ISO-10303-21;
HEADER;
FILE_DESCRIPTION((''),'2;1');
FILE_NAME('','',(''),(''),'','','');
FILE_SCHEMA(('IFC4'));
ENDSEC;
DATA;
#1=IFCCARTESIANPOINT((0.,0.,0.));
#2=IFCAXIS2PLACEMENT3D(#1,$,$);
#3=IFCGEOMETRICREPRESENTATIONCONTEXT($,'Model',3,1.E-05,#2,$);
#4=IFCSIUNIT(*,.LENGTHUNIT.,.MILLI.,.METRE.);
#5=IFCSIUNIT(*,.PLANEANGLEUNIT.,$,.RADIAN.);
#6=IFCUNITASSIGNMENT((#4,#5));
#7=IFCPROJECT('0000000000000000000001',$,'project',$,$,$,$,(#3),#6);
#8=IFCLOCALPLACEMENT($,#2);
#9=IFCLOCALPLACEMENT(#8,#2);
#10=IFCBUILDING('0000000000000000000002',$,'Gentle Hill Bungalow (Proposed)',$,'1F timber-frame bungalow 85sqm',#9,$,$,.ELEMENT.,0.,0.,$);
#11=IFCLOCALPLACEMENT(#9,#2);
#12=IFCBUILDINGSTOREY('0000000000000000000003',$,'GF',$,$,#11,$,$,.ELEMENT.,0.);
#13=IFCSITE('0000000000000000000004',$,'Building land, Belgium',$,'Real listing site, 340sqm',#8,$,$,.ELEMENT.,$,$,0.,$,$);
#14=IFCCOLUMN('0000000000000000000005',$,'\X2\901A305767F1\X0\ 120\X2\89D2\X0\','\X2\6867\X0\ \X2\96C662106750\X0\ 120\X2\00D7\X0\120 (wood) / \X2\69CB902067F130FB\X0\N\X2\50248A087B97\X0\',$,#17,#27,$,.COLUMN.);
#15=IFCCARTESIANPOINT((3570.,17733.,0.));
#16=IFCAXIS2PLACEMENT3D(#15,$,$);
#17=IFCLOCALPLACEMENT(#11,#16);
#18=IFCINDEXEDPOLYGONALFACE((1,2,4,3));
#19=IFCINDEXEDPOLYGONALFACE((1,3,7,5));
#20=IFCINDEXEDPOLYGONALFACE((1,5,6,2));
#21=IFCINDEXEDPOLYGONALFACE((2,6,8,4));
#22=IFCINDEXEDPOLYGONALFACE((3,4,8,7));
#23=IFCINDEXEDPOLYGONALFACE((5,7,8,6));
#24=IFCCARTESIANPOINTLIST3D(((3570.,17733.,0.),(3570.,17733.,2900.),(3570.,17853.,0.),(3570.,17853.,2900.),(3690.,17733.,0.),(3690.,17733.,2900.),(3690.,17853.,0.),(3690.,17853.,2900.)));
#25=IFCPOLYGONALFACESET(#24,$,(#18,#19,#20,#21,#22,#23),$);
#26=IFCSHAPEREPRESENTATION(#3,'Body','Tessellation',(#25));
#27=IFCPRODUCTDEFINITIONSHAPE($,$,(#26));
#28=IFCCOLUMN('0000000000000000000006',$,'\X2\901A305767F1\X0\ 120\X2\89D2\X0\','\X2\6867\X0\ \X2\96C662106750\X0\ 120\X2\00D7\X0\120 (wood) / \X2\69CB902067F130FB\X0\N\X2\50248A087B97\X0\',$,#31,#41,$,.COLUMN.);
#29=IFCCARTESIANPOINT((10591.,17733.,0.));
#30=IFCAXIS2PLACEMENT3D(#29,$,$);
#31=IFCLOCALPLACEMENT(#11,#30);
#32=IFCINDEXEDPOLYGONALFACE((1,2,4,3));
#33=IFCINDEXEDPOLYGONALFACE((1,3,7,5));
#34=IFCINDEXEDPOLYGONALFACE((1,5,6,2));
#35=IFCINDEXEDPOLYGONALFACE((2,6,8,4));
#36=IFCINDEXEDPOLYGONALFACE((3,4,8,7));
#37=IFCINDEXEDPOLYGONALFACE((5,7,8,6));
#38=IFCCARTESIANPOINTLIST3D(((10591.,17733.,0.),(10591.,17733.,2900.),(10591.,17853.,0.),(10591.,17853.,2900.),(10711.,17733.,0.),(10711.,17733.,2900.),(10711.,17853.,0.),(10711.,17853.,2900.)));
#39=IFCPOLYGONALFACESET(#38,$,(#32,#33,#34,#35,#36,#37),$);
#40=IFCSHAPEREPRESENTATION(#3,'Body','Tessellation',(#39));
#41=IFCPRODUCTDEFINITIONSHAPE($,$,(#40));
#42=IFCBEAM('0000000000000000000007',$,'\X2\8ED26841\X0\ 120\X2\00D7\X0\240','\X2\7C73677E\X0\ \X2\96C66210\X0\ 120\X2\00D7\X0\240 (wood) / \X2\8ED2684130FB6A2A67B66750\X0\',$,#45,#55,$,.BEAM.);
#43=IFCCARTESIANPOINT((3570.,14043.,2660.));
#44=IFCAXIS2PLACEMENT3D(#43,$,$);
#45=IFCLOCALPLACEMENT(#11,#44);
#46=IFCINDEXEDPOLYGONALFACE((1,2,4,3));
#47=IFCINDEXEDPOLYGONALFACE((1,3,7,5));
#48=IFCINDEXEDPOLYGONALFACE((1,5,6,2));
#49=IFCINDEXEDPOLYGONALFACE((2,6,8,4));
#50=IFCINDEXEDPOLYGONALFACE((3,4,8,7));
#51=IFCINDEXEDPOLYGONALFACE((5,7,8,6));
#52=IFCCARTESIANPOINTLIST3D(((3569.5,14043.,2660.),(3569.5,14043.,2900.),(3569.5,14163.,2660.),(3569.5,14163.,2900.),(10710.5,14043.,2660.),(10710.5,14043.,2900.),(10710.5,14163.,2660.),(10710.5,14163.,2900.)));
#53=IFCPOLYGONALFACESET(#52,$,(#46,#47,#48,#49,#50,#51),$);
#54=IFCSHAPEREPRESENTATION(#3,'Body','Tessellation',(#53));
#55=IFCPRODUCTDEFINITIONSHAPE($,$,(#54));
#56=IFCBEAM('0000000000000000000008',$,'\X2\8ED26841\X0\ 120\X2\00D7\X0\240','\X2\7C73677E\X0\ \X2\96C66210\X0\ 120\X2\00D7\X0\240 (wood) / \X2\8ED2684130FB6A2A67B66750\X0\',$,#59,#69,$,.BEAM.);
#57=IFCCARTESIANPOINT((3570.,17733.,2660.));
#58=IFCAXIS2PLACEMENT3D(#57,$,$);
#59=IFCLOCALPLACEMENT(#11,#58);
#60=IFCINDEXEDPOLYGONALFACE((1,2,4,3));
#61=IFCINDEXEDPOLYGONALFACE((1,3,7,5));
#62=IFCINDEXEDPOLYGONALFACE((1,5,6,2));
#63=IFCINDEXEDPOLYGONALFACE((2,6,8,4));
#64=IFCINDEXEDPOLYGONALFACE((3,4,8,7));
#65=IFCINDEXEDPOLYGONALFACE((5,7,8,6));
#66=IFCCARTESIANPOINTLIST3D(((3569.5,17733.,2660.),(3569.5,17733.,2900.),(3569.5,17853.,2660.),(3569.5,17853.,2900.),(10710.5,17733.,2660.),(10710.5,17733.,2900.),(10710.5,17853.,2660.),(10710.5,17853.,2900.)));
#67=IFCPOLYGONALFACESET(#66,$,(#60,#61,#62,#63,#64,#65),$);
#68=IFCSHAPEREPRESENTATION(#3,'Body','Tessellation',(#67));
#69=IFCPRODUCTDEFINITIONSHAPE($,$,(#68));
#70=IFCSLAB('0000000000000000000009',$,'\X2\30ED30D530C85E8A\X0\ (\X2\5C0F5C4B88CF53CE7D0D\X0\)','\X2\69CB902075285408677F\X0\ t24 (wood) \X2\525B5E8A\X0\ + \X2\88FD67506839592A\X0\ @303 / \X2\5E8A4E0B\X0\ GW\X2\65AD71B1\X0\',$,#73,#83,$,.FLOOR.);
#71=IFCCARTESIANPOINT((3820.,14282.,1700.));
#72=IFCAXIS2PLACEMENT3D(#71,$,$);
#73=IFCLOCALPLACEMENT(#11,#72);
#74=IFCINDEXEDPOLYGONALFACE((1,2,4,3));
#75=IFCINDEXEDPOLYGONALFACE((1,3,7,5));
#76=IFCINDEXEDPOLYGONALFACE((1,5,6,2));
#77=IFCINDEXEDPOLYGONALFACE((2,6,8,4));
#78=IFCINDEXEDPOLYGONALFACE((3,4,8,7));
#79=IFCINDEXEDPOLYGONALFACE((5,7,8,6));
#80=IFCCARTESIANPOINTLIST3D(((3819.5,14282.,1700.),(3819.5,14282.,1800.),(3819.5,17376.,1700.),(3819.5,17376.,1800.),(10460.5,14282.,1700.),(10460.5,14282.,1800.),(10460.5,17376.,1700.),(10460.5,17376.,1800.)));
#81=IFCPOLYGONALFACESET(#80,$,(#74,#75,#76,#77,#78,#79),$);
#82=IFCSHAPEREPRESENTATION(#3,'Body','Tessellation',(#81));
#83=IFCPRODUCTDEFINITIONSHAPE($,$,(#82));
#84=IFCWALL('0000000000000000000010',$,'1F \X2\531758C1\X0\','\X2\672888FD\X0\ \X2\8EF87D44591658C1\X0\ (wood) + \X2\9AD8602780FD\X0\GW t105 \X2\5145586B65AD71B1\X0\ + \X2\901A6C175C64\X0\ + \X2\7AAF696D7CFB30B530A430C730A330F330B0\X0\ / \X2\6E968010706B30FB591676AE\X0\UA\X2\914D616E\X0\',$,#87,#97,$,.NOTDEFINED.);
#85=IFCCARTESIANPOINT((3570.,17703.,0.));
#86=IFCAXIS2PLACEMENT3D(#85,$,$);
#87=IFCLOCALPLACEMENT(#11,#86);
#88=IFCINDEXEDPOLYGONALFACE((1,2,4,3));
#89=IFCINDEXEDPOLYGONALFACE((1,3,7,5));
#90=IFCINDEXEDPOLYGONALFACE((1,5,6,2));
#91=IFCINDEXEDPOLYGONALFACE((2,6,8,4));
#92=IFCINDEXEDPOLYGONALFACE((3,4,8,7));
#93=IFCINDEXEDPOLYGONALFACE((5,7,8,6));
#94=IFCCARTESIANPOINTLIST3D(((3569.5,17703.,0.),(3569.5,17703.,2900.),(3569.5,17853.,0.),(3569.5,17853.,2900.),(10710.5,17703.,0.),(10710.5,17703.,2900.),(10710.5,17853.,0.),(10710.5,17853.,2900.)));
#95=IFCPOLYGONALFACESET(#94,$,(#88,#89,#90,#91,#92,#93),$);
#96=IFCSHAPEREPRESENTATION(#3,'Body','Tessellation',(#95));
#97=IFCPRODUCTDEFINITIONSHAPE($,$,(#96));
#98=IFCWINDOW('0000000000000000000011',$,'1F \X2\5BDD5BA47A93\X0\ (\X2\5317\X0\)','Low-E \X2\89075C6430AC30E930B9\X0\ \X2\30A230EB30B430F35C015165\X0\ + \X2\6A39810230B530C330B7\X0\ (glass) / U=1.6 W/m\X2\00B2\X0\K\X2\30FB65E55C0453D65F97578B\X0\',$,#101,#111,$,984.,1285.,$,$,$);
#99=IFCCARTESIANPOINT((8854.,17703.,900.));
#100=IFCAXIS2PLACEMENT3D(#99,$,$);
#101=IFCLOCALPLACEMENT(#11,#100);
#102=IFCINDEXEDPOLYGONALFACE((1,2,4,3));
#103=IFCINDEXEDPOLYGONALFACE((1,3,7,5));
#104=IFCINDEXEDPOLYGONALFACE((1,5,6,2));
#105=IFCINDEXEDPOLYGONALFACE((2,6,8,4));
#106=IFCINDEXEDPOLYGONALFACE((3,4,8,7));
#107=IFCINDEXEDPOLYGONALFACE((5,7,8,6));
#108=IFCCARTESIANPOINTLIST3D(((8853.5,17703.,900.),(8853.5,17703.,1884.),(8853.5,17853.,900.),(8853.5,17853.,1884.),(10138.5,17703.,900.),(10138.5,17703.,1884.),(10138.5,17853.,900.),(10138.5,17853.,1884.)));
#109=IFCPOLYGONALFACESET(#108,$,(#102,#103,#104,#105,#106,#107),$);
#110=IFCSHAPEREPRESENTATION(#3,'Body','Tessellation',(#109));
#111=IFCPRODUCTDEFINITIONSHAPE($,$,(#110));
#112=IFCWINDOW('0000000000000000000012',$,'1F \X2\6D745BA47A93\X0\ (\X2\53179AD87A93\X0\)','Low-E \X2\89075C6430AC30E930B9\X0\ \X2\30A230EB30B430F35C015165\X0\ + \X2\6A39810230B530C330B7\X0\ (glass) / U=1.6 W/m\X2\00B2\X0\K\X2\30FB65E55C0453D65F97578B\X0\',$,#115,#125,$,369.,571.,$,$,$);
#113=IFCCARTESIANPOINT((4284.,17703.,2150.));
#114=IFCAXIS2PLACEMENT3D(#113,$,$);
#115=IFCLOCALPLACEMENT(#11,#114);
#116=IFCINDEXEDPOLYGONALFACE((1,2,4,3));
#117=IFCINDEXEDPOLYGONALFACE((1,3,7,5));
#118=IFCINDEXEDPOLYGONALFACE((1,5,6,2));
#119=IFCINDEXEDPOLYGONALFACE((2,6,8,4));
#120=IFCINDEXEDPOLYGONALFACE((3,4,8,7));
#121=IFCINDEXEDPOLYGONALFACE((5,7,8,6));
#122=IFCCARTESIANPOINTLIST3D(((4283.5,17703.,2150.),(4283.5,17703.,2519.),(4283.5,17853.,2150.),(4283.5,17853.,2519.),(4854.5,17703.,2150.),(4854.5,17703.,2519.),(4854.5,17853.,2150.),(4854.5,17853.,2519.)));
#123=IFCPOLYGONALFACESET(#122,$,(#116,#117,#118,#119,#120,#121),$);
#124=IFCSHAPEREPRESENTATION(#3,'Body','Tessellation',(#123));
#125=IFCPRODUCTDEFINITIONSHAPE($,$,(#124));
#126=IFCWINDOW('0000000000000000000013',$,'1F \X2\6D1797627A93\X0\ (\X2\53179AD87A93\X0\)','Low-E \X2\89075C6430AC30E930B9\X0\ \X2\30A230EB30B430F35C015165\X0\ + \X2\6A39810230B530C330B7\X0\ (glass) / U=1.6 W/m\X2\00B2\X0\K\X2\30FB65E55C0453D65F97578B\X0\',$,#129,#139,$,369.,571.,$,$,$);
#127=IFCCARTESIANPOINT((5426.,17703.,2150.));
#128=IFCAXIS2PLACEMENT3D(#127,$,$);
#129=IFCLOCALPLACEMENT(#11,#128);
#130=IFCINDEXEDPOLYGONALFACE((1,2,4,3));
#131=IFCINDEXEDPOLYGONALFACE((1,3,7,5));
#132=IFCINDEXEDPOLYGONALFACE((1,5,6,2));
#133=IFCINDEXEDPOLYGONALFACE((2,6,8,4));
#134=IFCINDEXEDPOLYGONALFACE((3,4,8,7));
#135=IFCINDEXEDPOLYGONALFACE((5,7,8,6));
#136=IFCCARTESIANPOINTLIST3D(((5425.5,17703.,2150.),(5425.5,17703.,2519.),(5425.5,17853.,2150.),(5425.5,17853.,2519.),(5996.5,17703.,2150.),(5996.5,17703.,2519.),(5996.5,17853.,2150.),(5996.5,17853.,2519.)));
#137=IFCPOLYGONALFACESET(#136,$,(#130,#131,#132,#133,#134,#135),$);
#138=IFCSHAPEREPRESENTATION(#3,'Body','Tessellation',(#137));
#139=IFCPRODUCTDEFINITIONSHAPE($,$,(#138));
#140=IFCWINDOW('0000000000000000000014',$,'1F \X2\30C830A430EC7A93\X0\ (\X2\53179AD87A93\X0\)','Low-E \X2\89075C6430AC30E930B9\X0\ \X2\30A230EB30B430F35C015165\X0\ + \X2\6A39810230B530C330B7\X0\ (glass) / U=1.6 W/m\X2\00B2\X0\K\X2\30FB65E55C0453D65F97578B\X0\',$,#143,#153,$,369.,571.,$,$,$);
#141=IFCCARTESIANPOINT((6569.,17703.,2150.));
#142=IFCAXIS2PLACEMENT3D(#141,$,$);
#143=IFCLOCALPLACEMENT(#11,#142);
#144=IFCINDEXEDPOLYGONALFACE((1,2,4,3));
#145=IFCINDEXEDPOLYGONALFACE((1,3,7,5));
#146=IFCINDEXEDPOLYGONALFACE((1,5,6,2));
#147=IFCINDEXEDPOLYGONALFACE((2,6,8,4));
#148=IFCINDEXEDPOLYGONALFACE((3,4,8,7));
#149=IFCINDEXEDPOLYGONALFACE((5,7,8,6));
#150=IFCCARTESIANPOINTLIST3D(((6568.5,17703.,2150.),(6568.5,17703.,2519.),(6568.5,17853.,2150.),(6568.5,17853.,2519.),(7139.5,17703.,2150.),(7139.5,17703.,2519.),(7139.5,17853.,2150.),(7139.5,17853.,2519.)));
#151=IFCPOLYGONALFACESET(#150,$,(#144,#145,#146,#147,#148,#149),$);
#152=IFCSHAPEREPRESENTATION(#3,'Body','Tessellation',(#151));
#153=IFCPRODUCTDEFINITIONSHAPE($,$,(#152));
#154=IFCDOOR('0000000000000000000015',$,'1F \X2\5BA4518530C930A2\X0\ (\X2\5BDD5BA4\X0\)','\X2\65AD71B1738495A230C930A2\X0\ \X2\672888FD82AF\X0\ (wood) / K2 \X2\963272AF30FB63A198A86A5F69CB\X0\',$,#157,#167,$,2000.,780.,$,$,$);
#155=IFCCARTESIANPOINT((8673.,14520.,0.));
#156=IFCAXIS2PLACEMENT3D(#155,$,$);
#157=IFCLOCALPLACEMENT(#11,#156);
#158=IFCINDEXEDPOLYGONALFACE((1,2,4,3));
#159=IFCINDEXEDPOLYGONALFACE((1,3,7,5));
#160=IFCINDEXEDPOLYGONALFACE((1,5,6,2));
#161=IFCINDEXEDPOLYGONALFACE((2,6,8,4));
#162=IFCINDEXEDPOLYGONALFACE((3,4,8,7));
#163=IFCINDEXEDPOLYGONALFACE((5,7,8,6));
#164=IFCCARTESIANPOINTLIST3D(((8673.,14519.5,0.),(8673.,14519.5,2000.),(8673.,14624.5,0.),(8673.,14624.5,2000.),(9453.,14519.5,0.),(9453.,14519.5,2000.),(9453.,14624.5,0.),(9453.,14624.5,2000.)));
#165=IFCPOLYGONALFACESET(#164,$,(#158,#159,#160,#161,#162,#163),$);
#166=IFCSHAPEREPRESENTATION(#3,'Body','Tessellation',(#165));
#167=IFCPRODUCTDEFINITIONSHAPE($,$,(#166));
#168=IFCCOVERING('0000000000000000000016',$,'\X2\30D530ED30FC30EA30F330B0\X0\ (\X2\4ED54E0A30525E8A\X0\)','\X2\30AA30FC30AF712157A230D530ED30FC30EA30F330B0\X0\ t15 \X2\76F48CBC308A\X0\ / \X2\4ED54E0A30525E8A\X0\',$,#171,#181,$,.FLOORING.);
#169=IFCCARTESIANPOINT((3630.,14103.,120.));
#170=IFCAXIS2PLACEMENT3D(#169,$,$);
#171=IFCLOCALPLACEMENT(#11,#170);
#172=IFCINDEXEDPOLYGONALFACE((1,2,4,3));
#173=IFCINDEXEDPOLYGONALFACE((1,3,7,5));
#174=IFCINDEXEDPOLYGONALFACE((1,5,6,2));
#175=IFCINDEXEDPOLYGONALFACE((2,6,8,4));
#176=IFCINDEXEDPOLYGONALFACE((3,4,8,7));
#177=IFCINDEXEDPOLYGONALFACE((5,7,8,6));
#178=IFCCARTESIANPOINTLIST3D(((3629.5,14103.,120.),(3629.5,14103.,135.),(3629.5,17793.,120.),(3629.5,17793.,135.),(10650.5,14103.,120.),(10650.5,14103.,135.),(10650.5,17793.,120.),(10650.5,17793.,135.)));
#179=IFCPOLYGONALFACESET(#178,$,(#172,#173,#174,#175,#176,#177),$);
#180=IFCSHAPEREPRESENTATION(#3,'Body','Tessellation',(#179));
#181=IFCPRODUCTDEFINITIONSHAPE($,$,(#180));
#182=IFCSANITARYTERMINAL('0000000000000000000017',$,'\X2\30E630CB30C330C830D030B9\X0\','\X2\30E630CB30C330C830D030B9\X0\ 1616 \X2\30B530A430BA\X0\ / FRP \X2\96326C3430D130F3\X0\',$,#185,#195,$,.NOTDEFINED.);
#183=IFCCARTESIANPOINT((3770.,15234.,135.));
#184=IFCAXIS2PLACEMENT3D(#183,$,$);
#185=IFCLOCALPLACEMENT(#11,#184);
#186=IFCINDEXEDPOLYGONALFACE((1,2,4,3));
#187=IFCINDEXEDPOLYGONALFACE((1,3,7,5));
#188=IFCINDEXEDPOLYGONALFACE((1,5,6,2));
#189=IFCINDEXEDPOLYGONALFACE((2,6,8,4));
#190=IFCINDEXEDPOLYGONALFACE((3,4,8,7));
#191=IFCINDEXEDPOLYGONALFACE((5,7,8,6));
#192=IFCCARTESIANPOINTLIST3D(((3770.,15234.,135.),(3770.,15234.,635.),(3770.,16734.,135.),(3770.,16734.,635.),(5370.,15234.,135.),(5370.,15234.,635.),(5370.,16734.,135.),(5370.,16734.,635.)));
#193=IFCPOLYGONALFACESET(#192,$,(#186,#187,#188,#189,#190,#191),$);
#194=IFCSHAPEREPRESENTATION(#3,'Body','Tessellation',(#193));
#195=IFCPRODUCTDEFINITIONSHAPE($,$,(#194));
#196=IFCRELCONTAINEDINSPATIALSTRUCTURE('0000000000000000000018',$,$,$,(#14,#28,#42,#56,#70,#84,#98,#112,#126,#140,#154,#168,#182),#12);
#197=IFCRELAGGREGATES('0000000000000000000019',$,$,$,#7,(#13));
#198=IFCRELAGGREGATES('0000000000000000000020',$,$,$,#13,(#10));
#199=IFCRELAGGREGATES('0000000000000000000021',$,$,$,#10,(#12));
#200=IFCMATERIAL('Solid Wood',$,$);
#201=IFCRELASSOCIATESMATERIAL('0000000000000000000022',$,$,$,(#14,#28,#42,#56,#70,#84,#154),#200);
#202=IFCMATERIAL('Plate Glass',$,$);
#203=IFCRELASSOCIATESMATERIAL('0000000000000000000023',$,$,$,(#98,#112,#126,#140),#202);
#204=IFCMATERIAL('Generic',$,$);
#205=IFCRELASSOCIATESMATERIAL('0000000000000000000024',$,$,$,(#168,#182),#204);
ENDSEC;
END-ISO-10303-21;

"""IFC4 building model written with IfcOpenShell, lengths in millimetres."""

from ifc_helpers import new_model, si_unit, frame, frame_2d, origin, place, context, project, spatial, rectangle, extrude, material, element, fill, save


model = new_model("IFC4")

# Units and contexts
model_context = context("Model", 3, precision=1e-05, world=origin())
ifc_project = project(units=[si_unit("LENGTHUNIT", "METRE", prefix="MILLI"), si_unit("PLANEANGLEUNIT", "RADIAN")], contexts=[model_context])

# Site, building, storey
site_placement = place(None, origin())
site = spatial("IfcSite", under=ifc_project, at=site_placement, Name="Building land, Belgium", ObjectType="Real listing site, 340sqm", CompositionType="ELEMENT", RefElevation=0.0)
building_placement = place(site_placement, origin())
building = spatial("IfcBuilding", under=site, at=building_placement, Name="Gentle Hill Bungalow (Proposed)", ObjectType="1F timber-frame bungalow 85sqm", CompositionType="ELEMENT", ElevationOfRefHeight=0.0, ElevationOfTerrain=0.0)
storey_placement = place(building_placement, origin())
storey = spatial("IfcBuildingStorey", under=building, at=storey_placement, Name="GF", CompositionType="ELEMENT", Elevation=0.0)

# Columns
ifc_material_1 = material(Name="Solid Wood")
column_1_placement = place(storey_placement, frame((3570.0, 17733.0, 0.0)))
element("IfcColumn", 1, at=column_1_placement, inside=storey, material=ifc_material_1, Name="通し柱 120角", Description="桧 集成材 120×120 (wood) / 構造柱・N値計算", PredefinedType="COLUMN", context=model_context, shape_type="SweptSolid", body=[
    extrude(rectangle(XDim=120.0, YDim=120.0, at=frame_2d((60.0, 60.0))), frame((3570.0, 17733.0, 0.0)), (0.0, 0.0, 1.0), 2900.0),
])
column_2_placement = place(storey_placement, frame((10591.0, 17733.0, 0.0)))
element("IfcColumn", 2, at=column_2_placement, inside=storey, material=ifc_material_1, Name="通し柱 120角", Description="桧 集成材 120×120 (wood) / 構造柱・N値計算", PredefinedType="COLUMN", context=model_context, shape_type="SweptSolid", body=[
    extrude(rectangle(XDim=120.0, YDim=120.0, at=frame_2d((60.0, 60.0))), frame((10591.0, 17733.0, 0.0)), (0.0, 0.0, 1.0), 2900.0),
])

# Beams
beam_1_placement = place(storey_placement, frame((3570.0, 14043.0, 2660.0)))
element("IfcBeam", 3, at=beam_1_placement, inside=storey, material=ifc_material_1, Name="軒桁 120×240", Description="米松 集成 120×240 (wood) / 軒桁・横架材", PredefinedType="BEAM", context=model_context, shape_type="SweptSolid", body=[
    extrude(rectangle(XDim=7141.0, YDim=120.0, at=frame_2d((3570.0, 60.0))), frame((3570.0, 14043.0, 2660.0)), (0.0, 0.0, 1.0), 240.0),
])
beam_2_placement = place(storey_placement, frame((3570.0, 17733.0, 2660.0)))
element("IfcBeam", 4, at=beam_2_placement, inside=storey, material=ifc_material_1, Name="軒桁 120×240", Description="米松 集成 120×240 (wood) / 軒桁・横架材", PredefinedType="BEAM", context=model_context, shape_type="SweptSolid", body=[
    extrude(rectangle(XDim=7141.0, YDim=120.0, at=frame_2d((3570.0, 60.0))), frame((3570.0, 17733.0, 2660.0)), (0.0, 0.0, 1.0), 240.0),
])

# Slab
slab_placement = place(storey_placement, frame((3820.0, 14282.0, 1700.0)))
element("IfcSlab", 5, at=slab_placement, inside=storey, material=ifc_material_1, Name="ロフト床 (小屋裏収納)", Description="構造用合板 t24 (wood) 剛床 + 製材根太 @303 / 床下 GW断熱", PredefinedType="FLOOR", context=model_context, shape_type="SweptSolid", body=[
    extrude(rectangle(XDim=6641.0, YDim=3094.0, at=frame_2d((3320.0, 1547.0))), frame((3820.0, 14282.0, 1700.0)), (0.0, 0.0, 1.0), 100.0),
])

# Wall, openings, windows
wall_1_placement = place(storey_placement, frame((3570.0, 17703.0, 0.0)))
wall_1 = element("IfcWall", 6, at=wall_1_placement, inside=storey, material=ifc_material_1, Name="1F 北壁", Description="木製 軸組外壁 (wood) + 高性能GW t105 充填断熱 + 通気層 + 窯業系サイディング / 準耐火・外皮UA配慮", PredefinedType="NOTDEFINED", context=model_context, shape_type="SweptSolid", body=[
    extrude(rectangle(XDim=7141.0, YDim=150.0, at=frame_2d((3570.0, 75.0))), frame((3570.0, 17703.0, 0.0)), (0.0, 0.0, 1.0), 2900.0),
])
opening_1_placement = place(storey_placement, frame((8854.0, 17703.0, 900.0)))
opening_1 = element("IfcOpeningElement", 7, at=opening_1_placement, cuts=wall_1, PredefinedType="NOTDEFINED", context=model_context, shape_type="SweptSolid", body=[
    extrude(rectangle(XDim=1285.0, YDim=150.0, at=frame_2d((642.0, 75.0))), frame((8854.0, 17703.0, 900.0)), (0.0, 0.0, 1.0), 984.0),
])
opening_2_placement = place(storey_placement, frame((4284.0, 17703.0, 2150.0)))
opening_2 = element("IfcOpeningElement", 8, at=opening_2_placement, cuts=wall_1, PredefinedType="NOTDEFINED", context=model_context, shape_type="SweptSolid", body=[
    extrude(rectangle(XDim=571.0, YDim=150.0, at=frame_2d((285.0, 75.0))), frame((4284.0, 17703.0, 2150.0)), (0.0, 0.0, 1.0), 369.0),
])
opening_3_placement = place(storey_placement, frame((5426.0, 17703.0, 2150.0)))
opening_3 = element("IfcOpeningElement", 9, at=opening_3_placement, cuts=wall_1, PredefinedType="NOTDEFINED", context=model_context, shape_type="SweptSolid", body=[
    extrude(rectangle(XDim=571.0, YDim=150.0, at=frame_2d((285.0, 75.0))), frame((5426.0, 17703.0, 2150.0)), (0.0, 0.0, 1.0), 369.0),
])
opening_4_placement = place(storey_placement, frame((6569.0, 17703.0, 2150.0)))
opening_4 = element("IfcOpeningElement", 10, at=opening_4_placement, cuts=wall_1, PredefinedType="NOTDEFINED", context=model_context, shape_type="SweptSolid", body=[
    extrude(rectangle(XDim=571.0, YDim=150.0, at=frame_2d((285.0, 75.0))), frame((6569.0, 17703.0, 2150.0)), (0.0, 0.0, 1.0), 369.0),
])
ifc_material_2 = material(Name="Plate Glass")
window_1_placement = place(storey_placement, frame((8854.0, 17703.0, 900.0)))
window_1 = element("IfcWindow", 11, at=window_1_placement, inside=storey, material=ifc_material_2, Name="1F 寝室窓 (北)", Description="Low-E 複層ガラス アルゴン封入 + 樹脂サッシ (glass) / U=1.6 W/m²K・日射取得型", OverallHeight=984.0, OverallWidth=1285.0, context=model_context, shape_type="SweptSolid", body=[
    extrude(rectangle(XDim=1285.0, YDim=150.0, at=frame_2d((642.0, 75.0))), frame((8854.0, 17703.0, 900.0)), (0.0, 0.0, 1.0), 984.0),
])
fill(opening_1, window_1)
window_2_placement = place(storey_placement, frame((4284.0, 17703.0, 2150.0)))
window_2 = element("IfcWindow", 12, at=window_2_placement, inside=storey, material=ifc_material_2, Name="1F 浴室窓 (北高窓)", Description="Low-E 複層ガラス アルゴン封入 + 樹脂サッシ (glass) / U=1.6 W/m²K・日射取得型", OverallHeight=369.0, OverallWidth=571.0, context=model_context, shape_type="SweptSolid", body=[
    extrude(rectangle(XDim=571.0, YDim=150.0, at=frame_2d((285.0, 75.0))), frame((4284.0, 17703.0, 2150.0)), (0.0, 0.0, 1.0), 369.0),
])
fill(opening_2, window_2)
window_3_placement = place(storey_placement, frame((5426.0, 17703.0, 2150.0)))
window_3 = element("IfcWindow", 13, at=window_3_placement, inside=storey, material=ifc_material_2, Name="1F 洗面窓 (北高窓)", Description="Low-E 複層ガラス アルゴン封入 + 樹脂サッシ (glass) / U=1.6 W/m²K・日射取得型", OverallHeight=369.0, OverallWidth=571.0, context=model_context, shape_type="SweptSolid", body=[
    extrude(rectangle(XDim=571.0, YDim=150.0, at=frame_2d((285.0, 75.0))), frame((5426.0, 17703.0, 2150.0)), (0.0, 0.0, 1.0), 369.0),
])
fill(opening_3, window_3)
window_4_placement = place(storey_placement, frame((6569.0, 17703.0, 2150.0)))
window_4 = element("IfcWindow", 14, at=window_4_placement, inside=storey, material=ifc_material_2, Name="1F トイレ窓 (北高窓)", Description="Low-E 複層ガラス アルゴン封入 + 樹脂サッシ (glass) / U=1.6 W/m²K・日射取得型", OverallHeight=369.0, OverallWidth=571.0, context=model_context, shape_type="SweptSolid", body=[
    extrude(rectangle(XDim=571.0, YDim=150.0, at=frame_2d((285.0, 75.0))), frame((6569.0, 17703.0, 2150.0)), (0.0, 0.0, 1.0), 369.0),
])
fill(opening_4, window_4)

# Door
door_1_placement = place(storey_placement, frame((8673.0, 14520.0, 0.0)))
element("IfcDoor", 15, at=door_1_placement, inside=storey, material=ifc_material_1, Name="1F 室内ドア (寝室)", Description="断熱玄関ドア 木製芯 (wood) / K2 防犯・採風機構", OverallHeight=2000.0, OverallWidth=780.0, context=model_context, shape_type="SweptSolid", body=[
    extrude(rectangle(XDim=780.0, YDim=105.0, at=frame_2d((390.0, 52.0))), frame((8673.0, 14520.0, 0.0)), (0.0, 0.0, 1.0), 2000.0),
])

# Covering
ifc_material_3 = material(Name="Generic")
covering_placement = place(storey_placement, frame((3630.0, 14103.0, 120.0)))
element("IfcCovering", 16, at=covering_placement, inside=storey, material=ifc_material_3, Name="フローリング (仕上げ床)", Description="オーク無垢フローリング t15 直貼り / 仕上げ床", PredefinedType="FLOORING", context=model_context, shape_type="SweptSolid", body=[
    extrude(rectangle(XDim=7021.0, YDim=3690.0, at=frame_2d((3510.0, 1845.0))), frame((3630.0, 14103.0, 120.0)), (0.0, 0.0, 1.0), 15.0),
])

# Sanitary terminal
sanitary_terminal_1_placement = place(storey_placement, frame((3770.0, 15234.0, 135.0)))
element("IfcSanitaryTerminal", 17, at=sanitary_terminal_1_placement, inside=storey, material=ifc_material_3, Name="ユニットバス", Description="ユニットバス 1616 サイズ / FRP 防水パン", PredefinedType="NOTDEFINED", context=model_context, shape_type="SweptSolid", body=[
    extrude(rectangle(XDim=1600.0, YDim=1500.0, at=frame_2d((800.0, 750.0))), frame((3770.0, 15234.0, 135.0)), (0.0, 0.0, 1.0), 500.0),
])

save(model, "model.ifc")
